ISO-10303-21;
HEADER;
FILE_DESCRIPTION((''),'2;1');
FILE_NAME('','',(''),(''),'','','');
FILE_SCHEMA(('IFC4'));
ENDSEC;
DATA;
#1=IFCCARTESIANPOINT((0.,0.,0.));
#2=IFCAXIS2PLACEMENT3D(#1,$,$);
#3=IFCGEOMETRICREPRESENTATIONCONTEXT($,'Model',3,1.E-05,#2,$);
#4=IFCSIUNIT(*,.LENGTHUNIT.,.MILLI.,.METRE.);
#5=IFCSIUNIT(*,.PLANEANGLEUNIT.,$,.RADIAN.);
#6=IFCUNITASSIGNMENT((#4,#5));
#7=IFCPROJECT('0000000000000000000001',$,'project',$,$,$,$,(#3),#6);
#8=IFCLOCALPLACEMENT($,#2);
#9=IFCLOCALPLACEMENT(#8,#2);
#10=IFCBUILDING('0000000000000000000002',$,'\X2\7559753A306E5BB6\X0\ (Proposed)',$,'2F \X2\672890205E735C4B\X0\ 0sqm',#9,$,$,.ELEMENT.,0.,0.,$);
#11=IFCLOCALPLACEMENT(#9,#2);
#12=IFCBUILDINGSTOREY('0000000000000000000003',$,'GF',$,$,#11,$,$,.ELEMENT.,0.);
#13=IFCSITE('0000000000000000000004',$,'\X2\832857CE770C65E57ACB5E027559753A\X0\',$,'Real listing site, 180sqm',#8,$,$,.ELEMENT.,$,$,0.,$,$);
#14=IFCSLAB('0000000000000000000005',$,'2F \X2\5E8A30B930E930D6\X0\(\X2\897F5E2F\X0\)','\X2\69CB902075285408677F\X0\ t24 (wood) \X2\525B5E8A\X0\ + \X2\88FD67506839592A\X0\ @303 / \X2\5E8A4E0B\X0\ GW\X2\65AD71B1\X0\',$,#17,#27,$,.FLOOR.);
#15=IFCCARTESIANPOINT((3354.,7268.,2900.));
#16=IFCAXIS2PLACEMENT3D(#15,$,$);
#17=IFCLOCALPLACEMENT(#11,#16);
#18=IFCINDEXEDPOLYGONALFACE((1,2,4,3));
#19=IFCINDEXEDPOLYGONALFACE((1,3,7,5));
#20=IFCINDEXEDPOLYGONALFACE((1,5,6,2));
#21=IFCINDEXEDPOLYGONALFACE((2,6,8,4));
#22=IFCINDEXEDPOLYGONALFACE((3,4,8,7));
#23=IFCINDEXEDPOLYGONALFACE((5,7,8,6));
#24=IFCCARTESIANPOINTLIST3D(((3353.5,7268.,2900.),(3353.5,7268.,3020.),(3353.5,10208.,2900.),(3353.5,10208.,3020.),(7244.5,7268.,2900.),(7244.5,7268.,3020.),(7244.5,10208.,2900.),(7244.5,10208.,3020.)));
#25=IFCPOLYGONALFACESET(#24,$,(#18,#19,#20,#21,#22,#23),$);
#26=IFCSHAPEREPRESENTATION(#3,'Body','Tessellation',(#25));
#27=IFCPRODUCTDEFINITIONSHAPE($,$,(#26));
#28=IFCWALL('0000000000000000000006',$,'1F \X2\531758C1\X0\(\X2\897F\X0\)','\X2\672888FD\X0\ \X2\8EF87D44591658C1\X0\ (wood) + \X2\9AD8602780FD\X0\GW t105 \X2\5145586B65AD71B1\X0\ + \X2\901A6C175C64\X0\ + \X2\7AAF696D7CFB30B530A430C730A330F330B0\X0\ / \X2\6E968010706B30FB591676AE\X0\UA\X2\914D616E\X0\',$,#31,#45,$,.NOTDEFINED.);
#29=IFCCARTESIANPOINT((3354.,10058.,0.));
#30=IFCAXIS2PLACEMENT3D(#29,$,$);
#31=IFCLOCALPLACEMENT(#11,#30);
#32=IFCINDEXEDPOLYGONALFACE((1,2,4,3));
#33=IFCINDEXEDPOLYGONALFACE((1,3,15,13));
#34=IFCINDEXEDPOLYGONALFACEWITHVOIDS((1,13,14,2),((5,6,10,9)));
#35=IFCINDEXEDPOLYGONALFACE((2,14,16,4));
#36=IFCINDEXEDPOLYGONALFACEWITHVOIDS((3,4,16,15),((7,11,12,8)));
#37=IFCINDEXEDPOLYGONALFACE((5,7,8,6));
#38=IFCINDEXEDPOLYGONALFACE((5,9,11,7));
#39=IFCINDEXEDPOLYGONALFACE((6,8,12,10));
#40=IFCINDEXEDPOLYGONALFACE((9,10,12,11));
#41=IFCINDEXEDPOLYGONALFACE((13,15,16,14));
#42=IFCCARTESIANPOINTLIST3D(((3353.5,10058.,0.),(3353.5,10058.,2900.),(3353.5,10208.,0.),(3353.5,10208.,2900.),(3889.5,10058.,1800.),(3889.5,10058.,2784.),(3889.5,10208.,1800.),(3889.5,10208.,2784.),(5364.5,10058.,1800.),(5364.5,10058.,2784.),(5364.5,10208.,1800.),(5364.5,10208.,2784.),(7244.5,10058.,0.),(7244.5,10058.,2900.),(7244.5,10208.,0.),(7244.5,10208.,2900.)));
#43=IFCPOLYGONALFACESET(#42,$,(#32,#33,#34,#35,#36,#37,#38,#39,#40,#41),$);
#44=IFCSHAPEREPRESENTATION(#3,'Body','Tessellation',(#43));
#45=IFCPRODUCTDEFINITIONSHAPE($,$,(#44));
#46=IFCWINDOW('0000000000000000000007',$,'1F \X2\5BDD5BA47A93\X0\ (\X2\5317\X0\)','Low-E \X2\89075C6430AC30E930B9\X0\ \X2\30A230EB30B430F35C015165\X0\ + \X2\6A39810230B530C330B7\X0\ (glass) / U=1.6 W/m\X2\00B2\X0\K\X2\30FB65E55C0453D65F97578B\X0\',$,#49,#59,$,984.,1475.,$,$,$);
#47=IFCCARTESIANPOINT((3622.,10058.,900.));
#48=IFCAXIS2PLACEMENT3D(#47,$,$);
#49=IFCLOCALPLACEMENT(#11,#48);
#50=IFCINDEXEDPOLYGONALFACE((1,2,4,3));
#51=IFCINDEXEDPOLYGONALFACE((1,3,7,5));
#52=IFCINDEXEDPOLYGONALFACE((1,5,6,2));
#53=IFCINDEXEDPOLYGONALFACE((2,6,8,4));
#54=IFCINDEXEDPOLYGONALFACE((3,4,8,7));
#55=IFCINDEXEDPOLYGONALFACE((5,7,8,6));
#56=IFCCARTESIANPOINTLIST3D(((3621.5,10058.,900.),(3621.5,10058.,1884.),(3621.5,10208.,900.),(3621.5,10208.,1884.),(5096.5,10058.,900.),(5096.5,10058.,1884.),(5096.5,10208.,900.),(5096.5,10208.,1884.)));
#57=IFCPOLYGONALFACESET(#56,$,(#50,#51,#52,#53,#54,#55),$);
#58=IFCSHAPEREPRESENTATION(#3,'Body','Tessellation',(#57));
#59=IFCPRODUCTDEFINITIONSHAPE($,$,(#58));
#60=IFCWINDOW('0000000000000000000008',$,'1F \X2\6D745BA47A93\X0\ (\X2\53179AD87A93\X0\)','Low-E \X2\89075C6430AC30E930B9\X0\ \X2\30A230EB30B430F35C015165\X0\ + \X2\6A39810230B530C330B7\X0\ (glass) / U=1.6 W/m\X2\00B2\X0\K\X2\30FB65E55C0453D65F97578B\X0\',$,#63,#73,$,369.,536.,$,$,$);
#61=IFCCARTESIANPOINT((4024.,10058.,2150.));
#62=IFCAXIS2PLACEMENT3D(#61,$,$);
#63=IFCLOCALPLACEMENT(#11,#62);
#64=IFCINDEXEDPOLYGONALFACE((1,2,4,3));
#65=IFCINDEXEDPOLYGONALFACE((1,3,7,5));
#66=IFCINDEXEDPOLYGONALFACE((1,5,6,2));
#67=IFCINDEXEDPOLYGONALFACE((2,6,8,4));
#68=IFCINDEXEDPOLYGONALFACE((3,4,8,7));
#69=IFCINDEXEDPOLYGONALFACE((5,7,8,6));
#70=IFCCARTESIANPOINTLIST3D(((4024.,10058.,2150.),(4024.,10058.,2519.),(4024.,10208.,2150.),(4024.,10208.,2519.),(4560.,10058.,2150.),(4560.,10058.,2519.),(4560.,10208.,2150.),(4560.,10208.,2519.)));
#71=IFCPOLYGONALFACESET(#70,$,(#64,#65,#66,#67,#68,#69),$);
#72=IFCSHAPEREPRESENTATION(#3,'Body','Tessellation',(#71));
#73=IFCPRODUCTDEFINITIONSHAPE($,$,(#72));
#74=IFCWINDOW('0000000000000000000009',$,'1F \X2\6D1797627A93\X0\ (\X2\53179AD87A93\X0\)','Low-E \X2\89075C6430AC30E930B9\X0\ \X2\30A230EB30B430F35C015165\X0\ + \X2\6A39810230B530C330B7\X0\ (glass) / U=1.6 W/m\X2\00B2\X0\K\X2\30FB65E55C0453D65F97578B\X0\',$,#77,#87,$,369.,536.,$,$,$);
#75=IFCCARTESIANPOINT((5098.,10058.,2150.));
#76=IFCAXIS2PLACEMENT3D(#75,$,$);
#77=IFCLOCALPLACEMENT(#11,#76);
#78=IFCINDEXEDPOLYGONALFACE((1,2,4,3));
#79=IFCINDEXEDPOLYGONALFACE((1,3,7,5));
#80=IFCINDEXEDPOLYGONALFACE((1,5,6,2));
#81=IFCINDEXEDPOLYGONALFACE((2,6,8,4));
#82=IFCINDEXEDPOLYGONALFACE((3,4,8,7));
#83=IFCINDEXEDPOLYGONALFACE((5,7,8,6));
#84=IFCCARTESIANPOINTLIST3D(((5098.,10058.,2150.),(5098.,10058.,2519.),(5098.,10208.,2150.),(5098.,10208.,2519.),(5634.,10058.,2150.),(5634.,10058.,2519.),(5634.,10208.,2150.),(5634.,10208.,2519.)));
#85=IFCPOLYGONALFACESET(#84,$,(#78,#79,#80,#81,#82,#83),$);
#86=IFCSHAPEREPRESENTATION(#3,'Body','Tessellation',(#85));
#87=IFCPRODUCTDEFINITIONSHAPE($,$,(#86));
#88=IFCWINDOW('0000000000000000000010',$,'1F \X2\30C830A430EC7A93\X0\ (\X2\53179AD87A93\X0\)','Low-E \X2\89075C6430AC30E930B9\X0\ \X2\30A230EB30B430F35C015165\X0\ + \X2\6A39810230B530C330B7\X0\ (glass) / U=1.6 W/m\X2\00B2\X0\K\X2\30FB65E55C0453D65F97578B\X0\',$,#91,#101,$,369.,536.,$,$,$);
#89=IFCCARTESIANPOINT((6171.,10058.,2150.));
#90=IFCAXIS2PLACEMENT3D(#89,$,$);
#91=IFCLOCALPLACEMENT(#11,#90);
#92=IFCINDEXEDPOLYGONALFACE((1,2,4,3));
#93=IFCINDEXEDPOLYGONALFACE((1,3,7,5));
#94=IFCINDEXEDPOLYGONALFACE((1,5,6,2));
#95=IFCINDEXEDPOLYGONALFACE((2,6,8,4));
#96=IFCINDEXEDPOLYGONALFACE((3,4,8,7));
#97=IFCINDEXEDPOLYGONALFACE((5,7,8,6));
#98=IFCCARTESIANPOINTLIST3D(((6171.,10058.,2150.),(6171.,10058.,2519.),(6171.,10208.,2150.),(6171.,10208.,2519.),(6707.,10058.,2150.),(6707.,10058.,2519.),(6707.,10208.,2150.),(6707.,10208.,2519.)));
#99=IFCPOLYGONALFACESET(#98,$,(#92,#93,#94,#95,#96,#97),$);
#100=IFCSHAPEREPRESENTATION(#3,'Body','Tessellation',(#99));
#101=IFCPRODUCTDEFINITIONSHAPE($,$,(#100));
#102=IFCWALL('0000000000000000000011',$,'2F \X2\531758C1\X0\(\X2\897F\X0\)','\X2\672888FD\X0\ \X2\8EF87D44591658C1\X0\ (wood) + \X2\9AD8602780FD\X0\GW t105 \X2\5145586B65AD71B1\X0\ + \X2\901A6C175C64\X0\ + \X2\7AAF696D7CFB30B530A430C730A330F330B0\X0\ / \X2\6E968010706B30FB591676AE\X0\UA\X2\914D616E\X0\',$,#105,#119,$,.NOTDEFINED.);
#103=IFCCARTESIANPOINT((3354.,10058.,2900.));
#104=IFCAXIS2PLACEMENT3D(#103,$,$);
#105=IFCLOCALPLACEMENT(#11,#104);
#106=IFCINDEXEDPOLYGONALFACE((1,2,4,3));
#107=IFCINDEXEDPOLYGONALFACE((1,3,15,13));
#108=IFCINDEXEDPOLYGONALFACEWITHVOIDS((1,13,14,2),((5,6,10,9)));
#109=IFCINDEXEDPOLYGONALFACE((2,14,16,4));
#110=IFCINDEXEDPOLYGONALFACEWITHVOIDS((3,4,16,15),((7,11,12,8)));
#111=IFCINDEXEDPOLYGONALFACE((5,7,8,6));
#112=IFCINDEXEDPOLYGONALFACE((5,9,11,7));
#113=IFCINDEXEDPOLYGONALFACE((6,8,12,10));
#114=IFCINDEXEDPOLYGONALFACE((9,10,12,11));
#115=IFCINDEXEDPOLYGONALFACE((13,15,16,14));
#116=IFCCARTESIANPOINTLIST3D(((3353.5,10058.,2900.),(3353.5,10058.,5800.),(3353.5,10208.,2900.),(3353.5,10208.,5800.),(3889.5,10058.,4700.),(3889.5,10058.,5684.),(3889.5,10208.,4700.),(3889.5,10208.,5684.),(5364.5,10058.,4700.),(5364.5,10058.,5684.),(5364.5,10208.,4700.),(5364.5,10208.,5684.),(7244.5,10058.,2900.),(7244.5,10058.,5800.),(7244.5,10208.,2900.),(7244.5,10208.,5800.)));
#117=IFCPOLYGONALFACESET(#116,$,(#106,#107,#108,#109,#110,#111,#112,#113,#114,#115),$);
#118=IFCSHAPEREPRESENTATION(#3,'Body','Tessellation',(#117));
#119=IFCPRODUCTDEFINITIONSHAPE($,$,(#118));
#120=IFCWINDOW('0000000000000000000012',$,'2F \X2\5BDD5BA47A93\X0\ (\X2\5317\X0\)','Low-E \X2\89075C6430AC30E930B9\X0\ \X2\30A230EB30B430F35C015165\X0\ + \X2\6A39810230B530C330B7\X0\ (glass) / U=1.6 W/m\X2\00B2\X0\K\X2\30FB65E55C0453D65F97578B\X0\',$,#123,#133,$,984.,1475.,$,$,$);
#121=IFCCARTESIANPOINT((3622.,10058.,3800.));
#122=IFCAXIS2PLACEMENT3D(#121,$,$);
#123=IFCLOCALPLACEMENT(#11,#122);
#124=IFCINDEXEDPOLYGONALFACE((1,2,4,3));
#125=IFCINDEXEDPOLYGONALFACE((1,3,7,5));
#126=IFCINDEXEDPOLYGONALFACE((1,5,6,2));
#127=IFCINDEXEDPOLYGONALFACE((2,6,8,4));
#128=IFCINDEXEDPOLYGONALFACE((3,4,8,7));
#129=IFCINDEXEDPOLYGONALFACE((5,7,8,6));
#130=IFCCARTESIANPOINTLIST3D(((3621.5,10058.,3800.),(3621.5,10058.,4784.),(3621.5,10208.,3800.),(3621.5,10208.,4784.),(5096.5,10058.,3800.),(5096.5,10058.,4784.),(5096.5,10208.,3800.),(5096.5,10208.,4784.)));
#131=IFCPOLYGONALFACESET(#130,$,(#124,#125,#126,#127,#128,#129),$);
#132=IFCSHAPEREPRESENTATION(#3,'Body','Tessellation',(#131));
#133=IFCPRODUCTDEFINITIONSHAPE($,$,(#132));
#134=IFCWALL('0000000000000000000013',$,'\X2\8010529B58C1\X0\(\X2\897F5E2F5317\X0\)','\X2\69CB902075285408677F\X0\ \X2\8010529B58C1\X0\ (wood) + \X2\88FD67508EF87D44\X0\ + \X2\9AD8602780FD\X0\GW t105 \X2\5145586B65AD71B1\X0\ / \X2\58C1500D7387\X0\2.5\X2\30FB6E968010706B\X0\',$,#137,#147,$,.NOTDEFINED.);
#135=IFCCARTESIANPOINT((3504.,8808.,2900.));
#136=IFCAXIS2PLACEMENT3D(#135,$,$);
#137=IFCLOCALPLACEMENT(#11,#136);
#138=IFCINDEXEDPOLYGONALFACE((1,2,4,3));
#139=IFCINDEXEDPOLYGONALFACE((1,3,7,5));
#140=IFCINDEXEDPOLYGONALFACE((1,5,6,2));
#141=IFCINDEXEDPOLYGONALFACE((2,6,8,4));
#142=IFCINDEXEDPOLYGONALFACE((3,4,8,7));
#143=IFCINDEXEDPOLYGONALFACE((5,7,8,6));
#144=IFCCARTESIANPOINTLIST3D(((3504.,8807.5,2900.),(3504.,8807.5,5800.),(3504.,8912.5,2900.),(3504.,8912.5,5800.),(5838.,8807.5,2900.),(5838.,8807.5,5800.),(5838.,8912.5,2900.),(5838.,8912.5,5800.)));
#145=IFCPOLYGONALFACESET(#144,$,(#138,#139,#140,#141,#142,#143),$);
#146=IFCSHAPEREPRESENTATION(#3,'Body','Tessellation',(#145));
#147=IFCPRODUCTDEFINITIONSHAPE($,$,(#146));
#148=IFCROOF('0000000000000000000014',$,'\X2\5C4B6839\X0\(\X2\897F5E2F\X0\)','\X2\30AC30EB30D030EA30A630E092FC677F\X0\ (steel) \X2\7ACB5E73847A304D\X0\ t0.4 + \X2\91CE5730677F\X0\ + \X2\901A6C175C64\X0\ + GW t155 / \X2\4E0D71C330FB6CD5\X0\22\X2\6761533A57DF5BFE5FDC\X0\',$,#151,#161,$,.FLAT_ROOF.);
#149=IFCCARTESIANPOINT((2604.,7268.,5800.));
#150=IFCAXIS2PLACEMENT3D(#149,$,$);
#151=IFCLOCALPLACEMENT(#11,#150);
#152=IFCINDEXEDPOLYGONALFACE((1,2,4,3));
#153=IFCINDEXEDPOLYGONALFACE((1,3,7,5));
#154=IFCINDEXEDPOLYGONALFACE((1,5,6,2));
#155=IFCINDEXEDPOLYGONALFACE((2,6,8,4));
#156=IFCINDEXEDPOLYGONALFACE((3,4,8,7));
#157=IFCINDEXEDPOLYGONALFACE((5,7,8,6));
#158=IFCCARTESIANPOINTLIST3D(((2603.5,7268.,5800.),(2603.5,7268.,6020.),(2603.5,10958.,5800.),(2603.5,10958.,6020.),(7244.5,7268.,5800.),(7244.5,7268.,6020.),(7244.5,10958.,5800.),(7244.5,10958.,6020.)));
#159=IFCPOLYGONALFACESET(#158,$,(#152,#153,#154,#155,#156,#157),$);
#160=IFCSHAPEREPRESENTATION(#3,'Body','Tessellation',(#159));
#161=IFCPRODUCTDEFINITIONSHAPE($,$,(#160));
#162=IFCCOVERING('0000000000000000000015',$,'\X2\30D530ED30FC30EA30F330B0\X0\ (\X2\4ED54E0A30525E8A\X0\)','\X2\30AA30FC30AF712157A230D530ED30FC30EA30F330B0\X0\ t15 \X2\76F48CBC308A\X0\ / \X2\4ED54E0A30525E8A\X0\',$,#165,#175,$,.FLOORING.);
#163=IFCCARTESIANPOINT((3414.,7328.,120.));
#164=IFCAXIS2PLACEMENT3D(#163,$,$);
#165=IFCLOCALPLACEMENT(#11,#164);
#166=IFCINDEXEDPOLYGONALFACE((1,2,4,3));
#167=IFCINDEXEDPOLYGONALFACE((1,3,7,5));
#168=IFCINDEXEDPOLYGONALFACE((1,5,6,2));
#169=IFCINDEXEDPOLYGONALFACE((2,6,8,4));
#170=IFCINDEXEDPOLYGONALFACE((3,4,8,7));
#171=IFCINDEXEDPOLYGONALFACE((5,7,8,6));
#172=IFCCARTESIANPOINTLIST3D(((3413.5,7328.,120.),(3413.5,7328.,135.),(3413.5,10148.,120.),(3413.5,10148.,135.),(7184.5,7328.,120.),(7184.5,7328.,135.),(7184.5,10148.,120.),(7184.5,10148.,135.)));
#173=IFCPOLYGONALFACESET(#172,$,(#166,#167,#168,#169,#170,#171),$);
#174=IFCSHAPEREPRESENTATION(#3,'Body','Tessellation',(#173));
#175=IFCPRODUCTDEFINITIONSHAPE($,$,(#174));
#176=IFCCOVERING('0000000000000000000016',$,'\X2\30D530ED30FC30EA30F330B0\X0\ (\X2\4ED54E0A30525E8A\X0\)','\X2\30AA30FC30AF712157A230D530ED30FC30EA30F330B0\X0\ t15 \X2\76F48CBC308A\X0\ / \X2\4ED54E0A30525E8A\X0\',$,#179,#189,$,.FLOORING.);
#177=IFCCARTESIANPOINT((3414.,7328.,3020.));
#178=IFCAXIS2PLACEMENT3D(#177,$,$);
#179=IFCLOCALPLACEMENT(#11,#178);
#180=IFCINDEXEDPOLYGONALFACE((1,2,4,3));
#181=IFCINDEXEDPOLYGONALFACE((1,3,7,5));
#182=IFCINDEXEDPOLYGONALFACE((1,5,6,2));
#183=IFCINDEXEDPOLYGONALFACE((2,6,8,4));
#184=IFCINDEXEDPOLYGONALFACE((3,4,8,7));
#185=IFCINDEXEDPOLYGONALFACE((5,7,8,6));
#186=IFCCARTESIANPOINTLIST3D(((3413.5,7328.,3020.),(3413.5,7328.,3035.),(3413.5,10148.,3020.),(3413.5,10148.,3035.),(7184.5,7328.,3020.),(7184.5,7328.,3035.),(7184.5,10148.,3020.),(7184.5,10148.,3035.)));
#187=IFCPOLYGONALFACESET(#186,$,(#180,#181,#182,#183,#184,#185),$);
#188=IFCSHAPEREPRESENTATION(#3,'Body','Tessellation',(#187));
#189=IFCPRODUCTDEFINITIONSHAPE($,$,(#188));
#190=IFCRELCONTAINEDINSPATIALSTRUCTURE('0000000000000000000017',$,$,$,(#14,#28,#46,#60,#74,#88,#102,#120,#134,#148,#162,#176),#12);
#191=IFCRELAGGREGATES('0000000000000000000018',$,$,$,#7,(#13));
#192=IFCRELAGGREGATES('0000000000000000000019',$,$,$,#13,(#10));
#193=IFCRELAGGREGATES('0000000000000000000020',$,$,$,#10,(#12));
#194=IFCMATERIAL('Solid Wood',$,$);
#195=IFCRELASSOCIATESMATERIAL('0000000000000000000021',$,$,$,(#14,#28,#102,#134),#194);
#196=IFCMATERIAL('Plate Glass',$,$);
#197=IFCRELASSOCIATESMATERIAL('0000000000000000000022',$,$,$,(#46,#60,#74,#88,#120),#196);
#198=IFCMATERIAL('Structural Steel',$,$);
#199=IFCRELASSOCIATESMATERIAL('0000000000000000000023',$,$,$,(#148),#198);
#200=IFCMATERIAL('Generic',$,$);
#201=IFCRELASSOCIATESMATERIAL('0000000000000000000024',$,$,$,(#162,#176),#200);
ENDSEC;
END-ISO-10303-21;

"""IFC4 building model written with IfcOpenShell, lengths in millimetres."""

from ifc_helpers import new_model, si_unit, frame, frame_2d, origin, place, context, project, spatial, rectangle, extrude, material, element, fill, save


model = new_model("IFC4")

# Units and contexts
model_context = context("Model", 3, precision=1e-05, world=origin())
ifc_project = project(units=[si_unit("LENGTHUNIT", "METRE", prefix="MILLI"), si_unit("PLANEANGLEUNIT", "RADIAN")], contexts=[model_context])

# Site, building, storey
site_placement = place(None, origin())
site = spatial("IfcSite", under=ifc_project, at=site_placement, Name="茨城県日立市留町", ObjectType="Real listing site, 180sqm", CompositionType="ELEMENT", RefElevation=0.0)
building_placement = place(site_placement, origin())
building = spatial("IfcBuilding", under=site, at=building_placement, Name="留町の家 (Proposed)", ObjectType="2F 木造平屋 0sqm", CompositionType="ELEMENT", ElevationOfRefHeight=0.0, ElevationOfTerrain=0.0)
storey_placement = place(building_placement, origin())
storey = spatial("IfcBuildingStorey", under=building, at=storey_placement, Name="GF", CompositionType="ELEMENT", Elevation=0.0)

# Slab
ifc_material_1 = material(Name="Solid Wood")
slab_1_placement = place(storey_placement, frame((3354.0, 7268.0, 2900.0)))
element("IfcSlab", 1, at=slab_1_placement, inside=storey, material=ifc_material_1, Name="2F 床スラブ(西帯)", Description="構造用合板 t24 (wood) 剛床 + 製材根太 @303 / 床下 GW断熱", PredefinedType="FLOOR", context=model_context, shape_type="SweptSolid", body=[
    extrude(rectangle(XDim=3891.0, YDim=2940.0, at=frame_2d((1945.0, 1470.0))), frame((3354.0, 7268.0, 2900.0)), (0.0, 0.0, 1.0), 120.0),
])

# Wall, openings, windows
wall_1_placement = place(storey_placement, frame((3354.0, 10058.0, 0.0)))
wall_1 = element("IfcWall", 2, at=wall_1_placement, inside=storey, material=ifc_material_1, Name="1F 北壁(西)", Description="木製 軸組外壁 (wood) + 高性能GW t105 充填断熱 + 通気層 + 窯業系サイディング / 準耐火・外皮UA配慮", PredefinedType="NOTDEFINED", context=model_context, shape_type="SweptSolid", body=[
    extrude(rectangle(XDim=3891.0, YDim=150.0, at=frame_2d((1945.0, 75.0))), frame((3354.0, 10058.0, 0.0)), (0.0, 0.0, 1.0), 2900.0),
])
opening_1_placement = place(storey_placement, frame((3622.0, 10058.0, 900.0)))
opening_1 = element("IfcOpeningElement", 3, at=opening_1_placement, cuts=wall_1, PredefinedType="NOTDEFINED", context=model_context, shape_type="SweptSolid", body=[
    extrude(rectangle(XDim=1475.0, YDim=150.0, at=frame_2d((737.0, 75.0))), frame((3622.0, 10058.0, 900.0)), (0.0, 0.0, 1.0), 984.0),
])
opening_2_placement = place(storey_placement, frame((4024.0, 10058.0, 2150.0)))
opening_2 = element("IfcOpeningElement", 4, at=opening_2_placement, cuts=wall_1, PredefinedType="NOTDEFINED", context=model_context, shape_type="SweptSolid", body=[
    extrude(rectangle(XDim=536.0, YDim=150.0, at=frame_2d((268.0, 75.0))), frame((4024.0, 10058.0, 2150.0)), (0.0, 0.0, 1.0), 369.0),
])
opening_3_placement = place(storey_placement, frame((5098.0, 10058.0, 2150.0)))
opening_3 = element("IfcOpeningElement", 5, at=opening_3_placement, cuts=wall_1, PredefinedType="NOTDEFINED", context=model_context, shape_type="SweptSolid", body=[
    extrude(rectangle(XDim=536.0, YDim=150.0, at=frame_2d((268.0, 75.0))), frame((5098.0, 10058.0, 2150.0)), (0.0, 0.0, 1.0), 369.0),
])
opening_4_placement = place(storey_placement, frame((6171.0, 10058.0, 2150.0)))
opening_4 = element("IfcOpeningElement", 6, at=opening_4_placement, cuts=wall_1, PredefinedType="NOTDEFINED", context=model_context, shape_type="SweptSolid", body=[
    extrude(rectangle(XDim=536.0, YDim=150.0, at=frame_2d((268.0, 75.0))), frame((6171.0, 10058.0, 2150.0)), (0.0, 0.0, 1.0), 369.0),
])
ifc_material_2 = material(Name="Plate Glass")
window_1_placement = place(storey_placement, frame((3622.0, 10058.0, 900.0)))
window_1 = element("IfcWindow", 7, at=window_1_placement, inside=storey, material=ifc_material_2, Name="1F 寝室窓 (北)", Description="Low-E 複層ガラス アルゴン封入 + 樹脂サッシ (glass) / U=1.6 W/m²K・日射取得型", OverallHeight=984.0, OverallWidth=1475.0, context=model_context, shape_type="SweptSolid", body=[
    extrude(rectangle(XDim=1475.0, YDim=150.0, at=frame_2d((737.0, 75.0))), frame((3622.0, 10058.0, 900.0)), (0.0, 0.0, 1.0), 984.0),
])
fill(opening_1, window_1)
window_2_placement = place(storey_placement, frame((4024.0, 10058.0, 2150.0)))
window_2 = element("IfcWindow", 8, at=window_2_placement, inside=storey, material=ifc_material_2, Name="1F 浴室窓 (北高窓)", Description="Low-E 複層ガラス アルゴン封入 + 樹脂サッシ (glass) / U=1.6 W/m²K・日射取得型", OverallHeight=369.0, OverallWidth=536.0, context=model_context, shape_type="SweptSolid", body=[
    extrude(rectangle(XDim=536.0, YDim=150.0, at=frame_2d((268.0, 75.0))), frame((4024.0, 10058.0, 2150.0)), (0.0, 0.0, 1.0), 369.0),
])
fill(opening_2, window_2)
window_3_placement = place(storey_placement, frame((5098.0, 10058.0, 2150.0)))
window_3 = element("IfcWindow", 9, at=window_3_placement, inside=storey, material=ifc_material_2, Name="1F 洗面窓 (北高窓)", Description="Low-E 複層ガラス アルゴン封入 + 樹脂サッシ (glass) / U=1.6 W/m²K・日射取得型", OverallHeight=369.0, OverallWidth=536.0, context=model_context, shape_type="SweptSolid", body=[
    extrude(rectangle(XDim=536.0, YDim=150.0, at=frame_2d((268.0, 75.0))), frame((5098.0, 10058.0, 2150.0)), (0.0, 0.0, 1.0), 369.0),
])
fill(opening_3, window_3)
window_4_placement = place(storey_placement, frame((6171.0, 10058.0, 2150.0)))
window_4 = element("IfcWindow", 10, at=window_4_placement, inside=storey, material=ifc_material_2, Name="1F トイレ窓 (北高窓)", Description="Low-E 複層ガラス アルゴン封入 + 樹脂サッシ (glass) / U=1.6 W/m²K・日射取得型", OverallHeight=369.0, OverallWidth=536.0, context=model_context, shape_type="SweptSolid", body=[
    extrude(rectangle(XDim=536.0, YDim=150.0, at=frame_2d((268.0, 75.0))), frame((6171.0, 10058.0, 2150.0)), (0.0, 0.0, 1.0), 369.0),
])
fill(opening_4, window_4)

# Wall, opening, window
wall_2_placement = place(storey_placement, frame((3354.0, 10058.0, 2900.0)))
wall_2 = element("IfcWall", 11, at=wall_2_placement, inside=storey, material=ifc_material_1, Name="2F 北壁(西)", Description="木製 軸組外壁 (wood) + 高性能GW t105 充填断熱 + 通気層 + 窯業系サイディング / 準耐火・外皮UA配慮", PredefinedType="NOTDEFINED", context=model_context, shape_type="SweptSolid", body=[
    extrude(rectangle(XDim=3891.0, YDim=150.0, at=frame_2d((1945.0, 75.0))), frame((3354.0, 10058.0, 2900.0)), (0.0, 0.0, 1.0), 2900.0),
])
opening_5_placement = place(storey_placement, frame((3622.0, 10058.0, 3800.0)))
opening_5 = element("IfcOpeningElement", 12, at=opening_5_placement, cuts=wall_2, PredefinedType="NOTDEFINED", context=model_context, shape_type="SweptSolid", body=[
    extrude(rectangle(XDim=1475.0, YDim=150.0, at=frame_2d((737.0, 75.0))), frame((3622.0, 10058.0, 3800.0)), (0.0, 0.0, 1.0), 984.0),
])
window_5_placement = place(storey_placement, frame((3622.0, 10058.0, 3800.0)))
window_5 = element("IfcWindow", 13, at=window_5_placement, inside=storey, material=ifc_material_2, Name="2F 寝室窓 (北)", Description="Low-E 複層ガラス アルゴン封入 + 樹脂サッシ (glass) / U=1.6 W/m²K・日射取得型", OverallHeight=984.0, OverallWidth=1475.0, context=model_context, shape_type="SweptSolid", body=[
    extrude(rectangle(XDim=1475.0, YDim=150.0, at=frame_2d((737.0, 75.0))), frame((3622.0, 10058.0, 3800.0)), (0.0, 0.0, 1.0), 984.0),
])
fill(opening_5, window_5)

# Wall
wall_3_placement = place(storey_placement, frame((3504.0, 8808.0, 2900.0)))
element("IfcWall", 14, at=wall_3_placement, inside=storey, material=ifc_material_1, Name="耐力壁(西帯北)", Description="構造用合板 耐力壁 (wood) + 製材軸組 + 高性能GW t105 充填断熱 / 壁倍率2.5・準耐火", PredefinedType="NOTDEFINED", context=model_context, shape_type="SweptSolid", body=[
    extrude(rectangle(XDim=2334.0, YDim=105.0, at=frame_2d((1167.0, 52.0))), frame((3504.0, 8808.0, 2900.0)), (0.0, 0.0, 1.0), 2900.0),
])

# Roof
ifc_material_3 = material(Name="Structural Steel")
for number, where, name in (
    (15, (2604.0, 7268.0, 5800.0), "屋根(西帯)"),
):
    element("IfcRoof", number, at=place(storey_placement, frame(where)), inside=storey, material=ifc_material_3, Name=name, Description="ガルバリウム鋼板 (steel) 立平葺き t0.4 + 野地板 + 通気層 + GW t155 / 不燃・法22条区域対応", PredefinedType="FLAT_ROOF", context=model_context, shape_type="SweptSolid", body=[
        extrude(rectangle(XDim=4641.0, YDim=3690.0, at=frame_2d((2320.0, 1845.0))), frame((2604.0, 7268.0, 5800.0)), (0.0, 0.0, 1.0), 220.0),
    ])

# Coverings
ifc_material_4 = material(Name="Generic")
covering_1_placement = place(storey_placement, frame((3414.0, 7328.0, 120.0)))
element("IfcCovering", 16, at=covering_1_placement, inside=storey, material=ifc_material_4, Name="フローリング (仕上げ床)", Description="オーク無垢フローリング t15 直貼り / 仕上げ床", PredefinedType="FLOORING", context=model_context, shape_type="SweptSolid", body=[
    extrude(rectangle(XDim=3771.0, YDim=2820.0, at=frame_2d((1885.0, 1410.0))), frame((3414.0, 7328.0, 120.0)), (0.0, 0.0, 1.0), 15.0),
])
covering_2_placement = place(storey_placement, frame((3414.0, 7328.0, 3020.0)))
element("IfcCovering", 17, at=covering_2_placement, inside=storey, material=ifc_material_4, Name="フローリング (仕上げ床)", Description="オーク無垢フローリング t15 直貼り / 仕上げ床", PredefinedType="FLOORING", context=model_context, shape_type="SweptSolid", body=[
    extrude(rectangle(XDim=3771.0, YDim=2820.0, at=frame_2d((1885.0, 1410.0))), frame((3414.0, 7328.0, 3020.0)), (0.0, 0.0, 1.0), 15.0),
])

save(model, "model.ifc")
